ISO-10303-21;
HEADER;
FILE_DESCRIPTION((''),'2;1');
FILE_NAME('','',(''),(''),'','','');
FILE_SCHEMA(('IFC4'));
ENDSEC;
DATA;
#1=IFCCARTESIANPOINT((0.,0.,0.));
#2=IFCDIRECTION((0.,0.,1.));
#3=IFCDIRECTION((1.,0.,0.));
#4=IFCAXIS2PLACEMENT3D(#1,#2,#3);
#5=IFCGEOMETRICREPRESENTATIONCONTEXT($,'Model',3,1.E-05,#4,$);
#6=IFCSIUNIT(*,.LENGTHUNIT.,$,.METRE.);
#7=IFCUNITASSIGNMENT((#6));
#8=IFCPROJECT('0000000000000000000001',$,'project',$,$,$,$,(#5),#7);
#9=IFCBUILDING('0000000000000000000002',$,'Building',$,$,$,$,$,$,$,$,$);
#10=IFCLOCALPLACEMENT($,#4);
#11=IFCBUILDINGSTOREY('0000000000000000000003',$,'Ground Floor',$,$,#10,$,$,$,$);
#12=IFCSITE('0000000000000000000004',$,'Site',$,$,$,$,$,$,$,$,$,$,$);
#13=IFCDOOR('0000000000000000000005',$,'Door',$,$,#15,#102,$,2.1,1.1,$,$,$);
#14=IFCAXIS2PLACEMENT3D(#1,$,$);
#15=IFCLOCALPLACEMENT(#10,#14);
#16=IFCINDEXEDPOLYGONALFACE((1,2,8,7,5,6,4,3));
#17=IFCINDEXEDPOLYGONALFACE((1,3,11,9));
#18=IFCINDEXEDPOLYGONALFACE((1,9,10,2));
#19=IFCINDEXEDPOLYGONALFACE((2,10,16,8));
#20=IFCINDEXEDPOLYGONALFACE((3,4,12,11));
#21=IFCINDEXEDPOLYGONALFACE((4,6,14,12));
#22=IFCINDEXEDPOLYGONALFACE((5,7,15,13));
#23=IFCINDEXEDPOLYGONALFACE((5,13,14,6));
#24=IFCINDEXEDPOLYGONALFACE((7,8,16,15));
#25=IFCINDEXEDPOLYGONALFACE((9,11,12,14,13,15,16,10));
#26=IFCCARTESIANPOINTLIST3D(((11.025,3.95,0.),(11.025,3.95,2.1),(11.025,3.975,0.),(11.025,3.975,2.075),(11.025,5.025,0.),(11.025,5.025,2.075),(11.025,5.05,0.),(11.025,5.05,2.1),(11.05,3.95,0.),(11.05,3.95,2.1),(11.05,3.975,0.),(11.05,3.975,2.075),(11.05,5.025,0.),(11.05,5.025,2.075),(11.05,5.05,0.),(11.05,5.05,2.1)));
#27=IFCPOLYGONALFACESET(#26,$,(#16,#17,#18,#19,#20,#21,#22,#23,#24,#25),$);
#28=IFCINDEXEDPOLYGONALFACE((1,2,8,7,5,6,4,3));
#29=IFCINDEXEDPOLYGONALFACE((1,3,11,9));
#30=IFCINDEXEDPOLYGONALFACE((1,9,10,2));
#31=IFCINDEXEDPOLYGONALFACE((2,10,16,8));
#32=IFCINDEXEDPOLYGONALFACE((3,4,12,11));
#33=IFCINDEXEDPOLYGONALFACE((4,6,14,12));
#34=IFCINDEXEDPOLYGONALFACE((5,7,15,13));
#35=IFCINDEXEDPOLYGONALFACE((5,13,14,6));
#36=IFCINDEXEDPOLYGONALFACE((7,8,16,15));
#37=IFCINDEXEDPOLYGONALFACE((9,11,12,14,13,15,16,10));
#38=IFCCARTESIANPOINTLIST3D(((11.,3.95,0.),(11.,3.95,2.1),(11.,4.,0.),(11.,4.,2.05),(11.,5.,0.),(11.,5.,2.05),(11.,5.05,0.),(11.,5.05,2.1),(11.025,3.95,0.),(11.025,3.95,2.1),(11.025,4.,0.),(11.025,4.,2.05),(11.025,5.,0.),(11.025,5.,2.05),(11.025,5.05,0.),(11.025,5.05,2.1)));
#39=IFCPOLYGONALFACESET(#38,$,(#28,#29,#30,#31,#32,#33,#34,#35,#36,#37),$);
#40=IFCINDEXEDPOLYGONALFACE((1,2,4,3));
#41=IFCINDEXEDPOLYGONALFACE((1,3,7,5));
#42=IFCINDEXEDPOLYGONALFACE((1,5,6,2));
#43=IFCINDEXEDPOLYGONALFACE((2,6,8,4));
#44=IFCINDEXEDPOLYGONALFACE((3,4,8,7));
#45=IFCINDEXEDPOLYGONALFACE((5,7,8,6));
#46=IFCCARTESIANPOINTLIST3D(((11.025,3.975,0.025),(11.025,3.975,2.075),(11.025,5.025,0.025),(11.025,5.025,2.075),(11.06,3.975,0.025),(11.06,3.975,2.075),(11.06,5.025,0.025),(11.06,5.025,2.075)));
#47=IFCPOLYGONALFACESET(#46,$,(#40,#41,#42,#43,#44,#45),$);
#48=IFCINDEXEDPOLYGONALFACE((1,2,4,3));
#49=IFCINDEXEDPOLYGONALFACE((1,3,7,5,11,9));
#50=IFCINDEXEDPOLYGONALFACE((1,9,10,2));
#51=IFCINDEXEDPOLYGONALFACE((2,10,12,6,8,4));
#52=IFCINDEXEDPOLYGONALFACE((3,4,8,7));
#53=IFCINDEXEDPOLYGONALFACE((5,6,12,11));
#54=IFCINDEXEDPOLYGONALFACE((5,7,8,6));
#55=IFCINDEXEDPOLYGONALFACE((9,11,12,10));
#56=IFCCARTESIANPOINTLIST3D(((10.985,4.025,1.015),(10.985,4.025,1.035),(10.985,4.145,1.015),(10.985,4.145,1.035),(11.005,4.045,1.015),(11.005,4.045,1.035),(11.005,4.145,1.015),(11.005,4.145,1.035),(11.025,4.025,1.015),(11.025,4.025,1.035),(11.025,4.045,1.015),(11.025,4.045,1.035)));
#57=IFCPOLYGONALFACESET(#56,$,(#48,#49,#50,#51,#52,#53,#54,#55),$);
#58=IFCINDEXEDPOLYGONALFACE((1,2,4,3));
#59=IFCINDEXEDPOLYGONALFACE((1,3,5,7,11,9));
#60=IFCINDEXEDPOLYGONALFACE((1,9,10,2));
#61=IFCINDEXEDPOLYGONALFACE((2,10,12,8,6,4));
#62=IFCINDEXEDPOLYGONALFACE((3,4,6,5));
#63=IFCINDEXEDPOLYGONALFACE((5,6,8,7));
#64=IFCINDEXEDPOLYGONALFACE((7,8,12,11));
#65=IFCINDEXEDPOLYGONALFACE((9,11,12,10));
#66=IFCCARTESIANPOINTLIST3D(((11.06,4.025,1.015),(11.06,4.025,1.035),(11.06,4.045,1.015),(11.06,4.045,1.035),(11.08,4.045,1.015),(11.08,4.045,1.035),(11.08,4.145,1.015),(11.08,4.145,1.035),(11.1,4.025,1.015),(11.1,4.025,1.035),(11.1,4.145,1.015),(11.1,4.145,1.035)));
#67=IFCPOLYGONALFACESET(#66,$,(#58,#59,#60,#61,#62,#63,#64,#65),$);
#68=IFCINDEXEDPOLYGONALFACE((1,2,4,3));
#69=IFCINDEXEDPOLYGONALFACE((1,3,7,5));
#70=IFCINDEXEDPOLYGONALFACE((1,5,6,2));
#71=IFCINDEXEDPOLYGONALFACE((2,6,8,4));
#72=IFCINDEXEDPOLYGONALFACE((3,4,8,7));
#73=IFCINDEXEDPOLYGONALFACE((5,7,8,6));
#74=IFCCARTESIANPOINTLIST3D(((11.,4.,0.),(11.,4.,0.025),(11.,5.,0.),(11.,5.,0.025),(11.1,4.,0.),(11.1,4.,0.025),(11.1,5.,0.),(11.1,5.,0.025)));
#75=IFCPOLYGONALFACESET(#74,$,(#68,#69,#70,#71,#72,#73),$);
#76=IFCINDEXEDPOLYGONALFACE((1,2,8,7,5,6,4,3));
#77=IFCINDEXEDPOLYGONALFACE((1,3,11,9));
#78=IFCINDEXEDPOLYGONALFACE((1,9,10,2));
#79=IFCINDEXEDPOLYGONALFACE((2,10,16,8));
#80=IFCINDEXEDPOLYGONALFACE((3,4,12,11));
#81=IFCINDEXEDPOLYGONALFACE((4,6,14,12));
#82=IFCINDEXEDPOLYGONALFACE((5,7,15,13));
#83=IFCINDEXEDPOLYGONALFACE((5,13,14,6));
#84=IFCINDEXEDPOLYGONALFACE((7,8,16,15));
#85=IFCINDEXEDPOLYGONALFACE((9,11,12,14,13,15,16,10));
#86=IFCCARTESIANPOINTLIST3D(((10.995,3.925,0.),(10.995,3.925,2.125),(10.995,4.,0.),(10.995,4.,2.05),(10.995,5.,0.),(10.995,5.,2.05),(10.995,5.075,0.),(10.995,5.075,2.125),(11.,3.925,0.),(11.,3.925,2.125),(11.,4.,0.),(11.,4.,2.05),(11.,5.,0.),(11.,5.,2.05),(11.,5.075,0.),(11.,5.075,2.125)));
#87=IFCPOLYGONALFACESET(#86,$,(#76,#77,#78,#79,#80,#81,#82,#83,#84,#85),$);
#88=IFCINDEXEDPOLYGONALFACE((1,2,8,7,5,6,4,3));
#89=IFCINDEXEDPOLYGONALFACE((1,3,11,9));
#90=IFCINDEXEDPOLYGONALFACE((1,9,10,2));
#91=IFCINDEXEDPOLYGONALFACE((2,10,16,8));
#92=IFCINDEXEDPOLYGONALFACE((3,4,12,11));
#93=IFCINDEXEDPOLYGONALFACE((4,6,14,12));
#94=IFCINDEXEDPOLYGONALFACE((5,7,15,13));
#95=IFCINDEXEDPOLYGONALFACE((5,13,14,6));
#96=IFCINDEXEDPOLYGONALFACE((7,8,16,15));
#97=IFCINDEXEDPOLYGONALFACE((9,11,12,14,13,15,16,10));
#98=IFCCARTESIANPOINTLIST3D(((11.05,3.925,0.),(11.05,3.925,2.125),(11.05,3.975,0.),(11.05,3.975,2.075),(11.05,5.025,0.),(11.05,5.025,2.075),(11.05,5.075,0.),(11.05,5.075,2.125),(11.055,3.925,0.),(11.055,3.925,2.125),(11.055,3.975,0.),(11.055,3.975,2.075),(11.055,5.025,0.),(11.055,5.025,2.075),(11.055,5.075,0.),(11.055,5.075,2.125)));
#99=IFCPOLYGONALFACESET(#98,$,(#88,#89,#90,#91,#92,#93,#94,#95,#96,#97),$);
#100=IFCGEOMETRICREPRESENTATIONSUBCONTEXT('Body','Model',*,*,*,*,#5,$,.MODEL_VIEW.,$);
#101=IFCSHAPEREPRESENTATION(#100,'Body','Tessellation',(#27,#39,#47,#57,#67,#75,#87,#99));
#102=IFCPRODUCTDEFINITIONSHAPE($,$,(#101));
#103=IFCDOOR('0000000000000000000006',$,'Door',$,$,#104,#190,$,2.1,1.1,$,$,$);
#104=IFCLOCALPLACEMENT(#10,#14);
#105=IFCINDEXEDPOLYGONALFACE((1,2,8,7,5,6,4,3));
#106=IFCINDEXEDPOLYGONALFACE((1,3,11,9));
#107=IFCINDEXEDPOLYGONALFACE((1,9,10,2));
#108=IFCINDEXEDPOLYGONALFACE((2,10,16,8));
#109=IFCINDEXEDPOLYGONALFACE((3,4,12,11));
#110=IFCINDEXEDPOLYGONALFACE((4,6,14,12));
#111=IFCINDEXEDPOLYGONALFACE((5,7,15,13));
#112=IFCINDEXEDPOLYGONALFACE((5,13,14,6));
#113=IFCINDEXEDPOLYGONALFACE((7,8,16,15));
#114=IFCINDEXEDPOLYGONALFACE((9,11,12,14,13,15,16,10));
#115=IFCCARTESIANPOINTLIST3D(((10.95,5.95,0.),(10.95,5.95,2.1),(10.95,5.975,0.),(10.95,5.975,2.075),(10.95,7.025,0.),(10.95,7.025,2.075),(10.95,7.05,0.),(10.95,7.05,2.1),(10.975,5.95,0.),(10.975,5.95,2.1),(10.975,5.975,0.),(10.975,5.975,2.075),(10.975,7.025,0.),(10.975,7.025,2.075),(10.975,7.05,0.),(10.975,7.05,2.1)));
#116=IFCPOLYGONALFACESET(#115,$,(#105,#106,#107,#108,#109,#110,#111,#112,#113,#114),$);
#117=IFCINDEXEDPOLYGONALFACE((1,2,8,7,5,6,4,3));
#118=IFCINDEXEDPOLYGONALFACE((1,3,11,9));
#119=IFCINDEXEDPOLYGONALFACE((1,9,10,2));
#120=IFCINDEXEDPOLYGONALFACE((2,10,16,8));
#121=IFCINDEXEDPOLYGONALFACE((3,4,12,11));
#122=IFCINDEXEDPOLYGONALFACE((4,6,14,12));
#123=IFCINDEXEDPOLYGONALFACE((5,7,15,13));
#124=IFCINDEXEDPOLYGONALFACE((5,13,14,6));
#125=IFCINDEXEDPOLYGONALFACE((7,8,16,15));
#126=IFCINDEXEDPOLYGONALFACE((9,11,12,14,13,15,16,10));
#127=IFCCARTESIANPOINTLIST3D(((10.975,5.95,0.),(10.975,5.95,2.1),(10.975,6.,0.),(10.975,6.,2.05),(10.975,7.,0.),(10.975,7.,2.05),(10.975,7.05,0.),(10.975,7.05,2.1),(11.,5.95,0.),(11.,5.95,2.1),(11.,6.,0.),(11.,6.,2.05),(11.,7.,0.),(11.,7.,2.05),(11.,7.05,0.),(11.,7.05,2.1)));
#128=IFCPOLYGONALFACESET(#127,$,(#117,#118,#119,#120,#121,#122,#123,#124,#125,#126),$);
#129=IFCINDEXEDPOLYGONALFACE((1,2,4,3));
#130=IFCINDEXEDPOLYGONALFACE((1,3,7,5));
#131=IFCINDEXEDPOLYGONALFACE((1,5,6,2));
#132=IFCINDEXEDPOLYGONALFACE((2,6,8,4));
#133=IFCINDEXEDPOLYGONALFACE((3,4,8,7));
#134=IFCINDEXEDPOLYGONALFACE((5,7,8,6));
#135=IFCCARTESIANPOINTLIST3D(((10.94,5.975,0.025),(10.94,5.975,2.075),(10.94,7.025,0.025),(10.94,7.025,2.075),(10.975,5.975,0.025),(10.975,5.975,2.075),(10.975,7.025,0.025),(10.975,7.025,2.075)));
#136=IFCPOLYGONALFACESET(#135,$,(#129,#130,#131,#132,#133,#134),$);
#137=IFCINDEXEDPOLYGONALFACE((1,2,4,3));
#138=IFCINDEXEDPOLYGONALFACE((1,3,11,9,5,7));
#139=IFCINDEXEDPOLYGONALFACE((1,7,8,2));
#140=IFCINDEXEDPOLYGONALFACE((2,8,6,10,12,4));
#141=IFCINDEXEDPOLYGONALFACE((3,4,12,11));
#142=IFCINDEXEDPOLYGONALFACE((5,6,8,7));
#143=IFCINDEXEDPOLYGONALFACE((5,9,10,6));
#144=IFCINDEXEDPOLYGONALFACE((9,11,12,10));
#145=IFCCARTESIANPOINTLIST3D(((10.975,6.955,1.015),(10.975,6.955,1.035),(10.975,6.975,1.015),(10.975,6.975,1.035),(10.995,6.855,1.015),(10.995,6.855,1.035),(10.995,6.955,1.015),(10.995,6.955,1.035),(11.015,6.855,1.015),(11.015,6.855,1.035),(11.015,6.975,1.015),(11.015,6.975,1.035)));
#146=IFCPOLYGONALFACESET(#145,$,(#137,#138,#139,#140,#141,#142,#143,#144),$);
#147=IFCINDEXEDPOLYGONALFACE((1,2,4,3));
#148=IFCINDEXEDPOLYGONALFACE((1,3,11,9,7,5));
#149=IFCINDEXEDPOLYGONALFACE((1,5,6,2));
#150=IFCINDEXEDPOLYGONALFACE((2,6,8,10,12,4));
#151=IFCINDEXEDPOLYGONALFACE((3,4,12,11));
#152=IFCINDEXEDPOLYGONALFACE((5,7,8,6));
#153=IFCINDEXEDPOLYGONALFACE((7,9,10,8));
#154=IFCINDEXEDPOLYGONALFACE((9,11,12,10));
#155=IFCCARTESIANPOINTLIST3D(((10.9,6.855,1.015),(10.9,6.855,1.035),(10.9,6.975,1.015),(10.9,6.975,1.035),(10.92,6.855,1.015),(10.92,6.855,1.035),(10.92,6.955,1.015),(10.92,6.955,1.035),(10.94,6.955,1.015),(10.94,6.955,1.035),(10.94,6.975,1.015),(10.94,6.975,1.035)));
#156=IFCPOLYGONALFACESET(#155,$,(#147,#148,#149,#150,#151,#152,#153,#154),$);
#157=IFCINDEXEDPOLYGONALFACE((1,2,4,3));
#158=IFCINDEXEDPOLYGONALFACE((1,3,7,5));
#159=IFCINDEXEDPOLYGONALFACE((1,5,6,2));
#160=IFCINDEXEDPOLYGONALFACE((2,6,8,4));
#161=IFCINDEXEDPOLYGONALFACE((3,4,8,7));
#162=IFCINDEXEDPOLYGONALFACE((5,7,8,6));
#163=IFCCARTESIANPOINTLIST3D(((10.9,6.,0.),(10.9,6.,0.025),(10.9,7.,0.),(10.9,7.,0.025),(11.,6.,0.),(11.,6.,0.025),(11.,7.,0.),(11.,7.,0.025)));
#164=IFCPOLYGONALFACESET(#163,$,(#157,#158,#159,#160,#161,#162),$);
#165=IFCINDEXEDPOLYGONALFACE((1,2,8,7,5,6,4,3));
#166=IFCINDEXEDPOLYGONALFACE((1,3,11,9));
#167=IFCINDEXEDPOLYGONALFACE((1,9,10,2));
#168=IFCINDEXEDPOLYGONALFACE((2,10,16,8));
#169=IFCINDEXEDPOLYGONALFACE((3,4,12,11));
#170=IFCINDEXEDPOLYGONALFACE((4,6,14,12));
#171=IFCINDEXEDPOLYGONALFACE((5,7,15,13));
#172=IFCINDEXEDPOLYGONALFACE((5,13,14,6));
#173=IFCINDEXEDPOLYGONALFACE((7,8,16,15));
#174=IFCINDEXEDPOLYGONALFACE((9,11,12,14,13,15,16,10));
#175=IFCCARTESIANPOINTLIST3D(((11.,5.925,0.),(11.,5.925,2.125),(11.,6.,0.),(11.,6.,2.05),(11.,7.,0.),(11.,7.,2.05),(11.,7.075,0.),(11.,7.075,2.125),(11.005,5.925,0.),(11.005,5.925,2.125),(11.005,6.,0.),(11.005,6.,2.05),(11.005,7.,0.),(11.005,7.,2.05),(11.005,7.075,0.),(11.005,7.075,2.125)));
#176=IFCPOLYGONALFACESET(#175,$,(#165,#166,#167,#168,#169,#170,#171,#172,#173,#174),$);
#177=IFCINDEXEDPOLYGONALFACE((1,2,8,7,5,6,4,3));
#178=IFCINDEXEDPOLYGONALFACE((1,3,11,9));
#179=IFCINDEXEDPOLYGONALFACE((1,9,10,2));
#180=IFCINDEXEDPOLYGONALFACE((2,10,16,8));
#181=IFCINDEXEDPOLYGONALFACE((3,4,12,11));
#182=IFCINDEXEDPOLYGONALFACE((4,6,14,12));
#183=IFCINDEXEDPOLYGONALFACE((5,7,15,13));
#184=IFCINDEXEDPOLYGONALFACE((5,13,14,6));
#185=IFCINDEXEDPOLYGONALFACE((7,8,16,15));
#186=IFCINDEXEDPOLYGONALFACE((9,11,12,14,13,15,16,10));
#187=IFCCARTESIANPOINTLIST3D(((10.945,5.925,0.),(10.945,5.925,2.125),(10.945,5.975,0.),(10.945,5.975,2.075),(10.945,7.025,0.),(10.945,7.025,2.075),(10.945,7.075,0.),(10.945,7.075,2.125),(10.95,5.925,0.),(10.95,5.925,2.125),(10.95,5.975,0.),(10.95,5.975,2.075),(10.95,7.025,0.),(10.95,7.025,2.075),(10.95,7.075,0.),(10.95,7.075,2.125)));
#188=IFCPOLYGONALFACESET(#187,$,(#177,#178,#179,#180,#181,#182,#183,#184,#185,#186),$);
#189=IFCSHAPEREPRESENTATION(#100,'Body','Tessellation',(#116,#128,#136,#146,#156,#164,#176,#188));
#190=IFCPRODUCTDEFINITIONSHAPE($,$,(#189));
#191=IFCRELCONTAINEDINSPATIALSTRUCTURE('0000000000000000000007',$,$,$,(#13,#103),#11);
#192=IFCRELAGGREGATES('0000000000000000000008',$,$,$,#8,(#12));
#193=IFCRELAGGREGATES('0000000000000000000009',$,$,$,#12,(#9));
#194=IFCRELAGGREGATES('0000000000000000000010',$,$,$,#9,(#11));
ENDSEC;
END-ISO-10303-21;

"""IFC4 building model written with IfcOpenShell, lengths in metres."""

from ifc_helpers import new_model, si_unit, frame, origin_with_axes, place, context, subcontext, project, spatial, line, indexed_curve, outline, extrude, element, save


model = new_model("IFC4")

# Units and contexts
model_context = context("Model", 3, precision=1e-05, world=origin_with_axes())
body_context = subcontext(model_context, "Body", "Model", "MODEL_VIEW")
ifc_project = project(units=[si_unit("LENGTHUNIT", "METRE")], contexts=[model_context])

# Site, building, storey
site = spatial("IfcSite", under=ifc_project, Name="Site")
building = spatial("IfcBuilding", under=site, Name="Building")
storey_placement = place(None, origin_with_axes())
storey = spatial("IfcBuildingStorey", under=building, at=storey_placement, Name="Ground Floor")

# Doors
door_1_placement = place(storey_placement, frame((11.0, 5.05, 0.0), z_axis=(0.0, 0.0, 1.0), x_axis=(0.0, -1.0, 0.0)))
element("IfcDoor", 1, at=door_1_placement, inside=storey, Name="Door", OverallHeight=2.1, OverallWidth=1.1, context=body_context, shape_type="SweptSolid", body=[
    extrude(outline(indexed_curve([(0.0, 0.0), (0.0, 2.1), (1.1, 2.1), (1.1, 0.0), (1.075, 0.0), (1.075, 2.075), (0.025, 2.075), (0.025, 0.0)], segments=[line(1, 2, 3, 4, 5, 6, 7, 8, 1)])), frame((0.0, 0.025, 0.0), z_axis=(0.0, -1.0, 0.0), x_axis=(1.0, 0.0, 0.0)), (0.0, 0.0, -1.0), 0.025),
    extrude(outline(indexed_curve([(0.0, 0.0), (0.0, 2.1), (1.1, 2.1), (1.1, 0.0), (1.05, 0.0), (1.05, 2.05), (0.05, 2.05), (0.05, 0.0)], segments=[line(1, 2, 3, 4, 5, 6, 7, 8, 1)])), frame((0.0, 0.0, 0.0), z_axis=(0.0, -1.0, 0.0), x_axis=(1.0, 0.0, 0.0)), (0.0, 0.0, -1.0), 0.025),
    extrude(outline(indexed_curve([(0.0, 0.0), (1.05, 0.0), (1.05, 0.035), (0.0, 0.035)], segments=[line(1, 2, 3, 4, 1)])), frame((0.025, 0.025, 0.025), z_axis=(0.0, 0.0, 1.0), x_axis=(1.0, 0.0, 0.0)), (0.0, 0.0, 1.0), 2.05),
    extrude(outline(indexed_curve([(0.0, 0.0), (0.0, -0.04), (-0.12, -0.04), (-0.12, -0.02), (-0.02, -0.02), (-0.02, 0.0)], segments=[line(1, 2, 3, 4, 5, 6, 1)])), frame((1.025, 0.025, 1.015), z_axis=(0.0, 0.0, 1.0), x_axis=(1.0, 0.0, 0.0)), (0.0, 0.0, 1.0), 0.02),
    extrude(outline(indexed_curve([(0.0, 0.0), (0.0, 0.04), (-0.12, 0.04), (-0.12, 0.02), (-0.02, 0.02), (-0.02, 0.0)], segments=[line(1, 2, 3, 4, 5, 6, 1)])), frame((1.025, 0.06, 1.015), z_axis=(0.0, 0.0, 1.0), x_axis=(1.0, 0.0, 0.0)), (0.0, 0.0, 1.0), 0.02),
    extrude(outline(indexed_curve([(0.0, 0.0), (1.0, 0.0), (1.0, 0.1), (0.0, 0.1)], segments=[line(1, 2, 3, 4, 1)])), frame((0.05, 0.0, 0.0), z_axis=(0.0, 0.0, 1.0), x_axis=(1.0, 0.0, 0.0)), (0.0, 0.0, 1.0), 0.025),
    extrude(outline(indexed_curve([(0.0, 0.0), (0.0, 2.125), (1.15, 2.125), (1.15, 0.0), (1.075, 0.0), (1.075, 2.05), (0.075, 2.05), (0.075, 0.0)], segments=[line(1, 2, 3, 4, 5, 6, 7, 8, 1)])), frame((-0.025, -0.005, 0.0), z_axis=(0.0, -1.0, 0.0), x_axis=(1.0, 0.0, 0.0)), (0.0, 0.0, -1.0), 0.005),
    extrude(outline(indexed_curve([(0.0, 0.0), (0.0, 2.125), (1.15, 2.125), (1.15, 0.0), (1.1, 0.0), (1.1, 2.075), (0.05, 2.075), (0.05, 0.0)], segments=[line(1, 2, 3, 4, 5, 6, 7, 8, 1)])), frame((-0.025, 0.05, 0.0), z_axis=(0.0, -1.0, 0.0), x_axis=(1.0, 0.0, 0.0)), (0.0, 0.0, -1.0), 0.005),
])
door_2_placement = place(storey_placement, frame((11.0, 5.95, 0.0), z_axis=(0.0, 0.0, 1.0), x_axis=(0.0, 1.0, 0.0)))
element("IfcDoor", 2, at=door_2_placement, inside=storey, Name="Door", OverallHeight=2.1, OverallWidth=1.1, context=body_context, shape_type="SweptSolid", body=[
    extrude(outline(indexed_curve([(0.0, 0.0), (0.0, 2.1), (1.1, 2.1), (1.1, 0.0), (1.075, 0.0), (1.075, 2.075), (0.025, 2.075), (0.025, 0.0)], segments=[line(1, 2, 3, 4, 5, 6, 7, 8, 1)])), frame((0.0, 0.025, 0.0), z_axis=(0.0, -1.0, 0.0), x_axis=(1.0, 0.0, 0.0)), (0.0, 0.0, -1.0), 0.025),
    extrude(outline(indexed_curve([(0.0, 0.0), (0.0, 2.1), (1.1, 2.1), (1.1, 0.0), (1.05, 0.0), (1.05, 2.05), (0.05, 2.05), (0.05, 0.0)], segments=[line(1, 2, 3, 4, 5, 6, 7, 8, 1)])), frame((0.0, 0.0, 0.0), z_axis=(0.0, -1.0, 0.0), x_axis=(1.0, 0.0, 0.0)), (0.0, 0.0, -1.0), 0.025),
    extrude(outline(indexed_curve([(0.0, 0.0), (1.05, 0.0), (1.05, 0.035), (0.0, 0.035)], segments=[line(1, 2, 3, 4, 1)])), frame((0.025, 0.025, 0.025), z_axis=(0.0, 0.0, 1.0), x_axis=(1.0, 0.0, 0.0)), (0.0, 0.0, 1.0), 2.05),
    extrude(outline(indexed_curve([(0.0, 0.0), (0.0, -0.04), (-0.12, -0.04), (-0.12, -0.02), (-0.02, -0.02), (-0.02, 0.0)], segments=[line(1, 2, 3, 4, 5, 6, 1)])), frame((1.025, 0.025, 1.015), z_axis=(0.0, 0.0, 1.0), x_axis=(1.0, 0.0, 0.0)), (0.0, 0.0, 1.0), 0.02),
    extrude(outline(indexed_curve([(0.0, 0.0), (0.0, 0.04), (-0.12, 0.04), (-0.12, 0.02), (-0.02, 0.02), (-0.02, 0.0)], segments=[line(1, 2, 3, 4, 5, 6, 1)])), frame((1.025, 0.06, 1.015), z_axis=(0.0, 0.0, 1.0), x_axis=(1.0, 0.0, 0.0)), (0.0, 0.0, 1.0), 0.02),
    extrude(outline(indexed_curve([(0.0, 0.0), (1.0, 0.0), (1.0, 0.1), (0.0, 0.1)], segments=[line(1, 2, 3, 4, 1)])), frame((0.05, 0.0, 0.0), z_axis=(0.0, 0.0, 1.0), x_axis=(1.0, 0.0, 0.0)), (0.0, 0.0, 1.0), 0.025),
    extrude(outline(indexed_curve([(0.0, 0.0), (0.0, 2.125), (1.15, 2.125), (1.15, 0.0), (1.075, 0.0), (1.075, 2.05), (0.075, 2.05), (0.075, 0.0)], segments=[line(1, 2, 3, 4, 5, 6, 7, 8, 1)])), frame((-0.025, -0.005, 0.0), z_axis=(0.0, -1.0, 0.0), x_axis=(1.0, 0.0, 0.0)), (0.0, 0.0, -1.0), 0.005),
    extrude(outline(indexed_curve([(0.0, 0.0), (0.0, 2.125), (1.15, 2.125), (1.15, 0.0), (1.1, 0.0), (1.1, 2.075), (0.05, 2.075), (0.05, 0.0)], segments=[line(1, 2, 3, 4, 5, 6, 7, 8, 1)])), frame((-0.025, 0.05, 0.0), z_axis=(0.0, -1.0, 0.0), x_axis=(1.0, 0.0, 0.0)), (0.0, 0.0, -1.0), 0.005),
])

save(model, "model.ifc")
